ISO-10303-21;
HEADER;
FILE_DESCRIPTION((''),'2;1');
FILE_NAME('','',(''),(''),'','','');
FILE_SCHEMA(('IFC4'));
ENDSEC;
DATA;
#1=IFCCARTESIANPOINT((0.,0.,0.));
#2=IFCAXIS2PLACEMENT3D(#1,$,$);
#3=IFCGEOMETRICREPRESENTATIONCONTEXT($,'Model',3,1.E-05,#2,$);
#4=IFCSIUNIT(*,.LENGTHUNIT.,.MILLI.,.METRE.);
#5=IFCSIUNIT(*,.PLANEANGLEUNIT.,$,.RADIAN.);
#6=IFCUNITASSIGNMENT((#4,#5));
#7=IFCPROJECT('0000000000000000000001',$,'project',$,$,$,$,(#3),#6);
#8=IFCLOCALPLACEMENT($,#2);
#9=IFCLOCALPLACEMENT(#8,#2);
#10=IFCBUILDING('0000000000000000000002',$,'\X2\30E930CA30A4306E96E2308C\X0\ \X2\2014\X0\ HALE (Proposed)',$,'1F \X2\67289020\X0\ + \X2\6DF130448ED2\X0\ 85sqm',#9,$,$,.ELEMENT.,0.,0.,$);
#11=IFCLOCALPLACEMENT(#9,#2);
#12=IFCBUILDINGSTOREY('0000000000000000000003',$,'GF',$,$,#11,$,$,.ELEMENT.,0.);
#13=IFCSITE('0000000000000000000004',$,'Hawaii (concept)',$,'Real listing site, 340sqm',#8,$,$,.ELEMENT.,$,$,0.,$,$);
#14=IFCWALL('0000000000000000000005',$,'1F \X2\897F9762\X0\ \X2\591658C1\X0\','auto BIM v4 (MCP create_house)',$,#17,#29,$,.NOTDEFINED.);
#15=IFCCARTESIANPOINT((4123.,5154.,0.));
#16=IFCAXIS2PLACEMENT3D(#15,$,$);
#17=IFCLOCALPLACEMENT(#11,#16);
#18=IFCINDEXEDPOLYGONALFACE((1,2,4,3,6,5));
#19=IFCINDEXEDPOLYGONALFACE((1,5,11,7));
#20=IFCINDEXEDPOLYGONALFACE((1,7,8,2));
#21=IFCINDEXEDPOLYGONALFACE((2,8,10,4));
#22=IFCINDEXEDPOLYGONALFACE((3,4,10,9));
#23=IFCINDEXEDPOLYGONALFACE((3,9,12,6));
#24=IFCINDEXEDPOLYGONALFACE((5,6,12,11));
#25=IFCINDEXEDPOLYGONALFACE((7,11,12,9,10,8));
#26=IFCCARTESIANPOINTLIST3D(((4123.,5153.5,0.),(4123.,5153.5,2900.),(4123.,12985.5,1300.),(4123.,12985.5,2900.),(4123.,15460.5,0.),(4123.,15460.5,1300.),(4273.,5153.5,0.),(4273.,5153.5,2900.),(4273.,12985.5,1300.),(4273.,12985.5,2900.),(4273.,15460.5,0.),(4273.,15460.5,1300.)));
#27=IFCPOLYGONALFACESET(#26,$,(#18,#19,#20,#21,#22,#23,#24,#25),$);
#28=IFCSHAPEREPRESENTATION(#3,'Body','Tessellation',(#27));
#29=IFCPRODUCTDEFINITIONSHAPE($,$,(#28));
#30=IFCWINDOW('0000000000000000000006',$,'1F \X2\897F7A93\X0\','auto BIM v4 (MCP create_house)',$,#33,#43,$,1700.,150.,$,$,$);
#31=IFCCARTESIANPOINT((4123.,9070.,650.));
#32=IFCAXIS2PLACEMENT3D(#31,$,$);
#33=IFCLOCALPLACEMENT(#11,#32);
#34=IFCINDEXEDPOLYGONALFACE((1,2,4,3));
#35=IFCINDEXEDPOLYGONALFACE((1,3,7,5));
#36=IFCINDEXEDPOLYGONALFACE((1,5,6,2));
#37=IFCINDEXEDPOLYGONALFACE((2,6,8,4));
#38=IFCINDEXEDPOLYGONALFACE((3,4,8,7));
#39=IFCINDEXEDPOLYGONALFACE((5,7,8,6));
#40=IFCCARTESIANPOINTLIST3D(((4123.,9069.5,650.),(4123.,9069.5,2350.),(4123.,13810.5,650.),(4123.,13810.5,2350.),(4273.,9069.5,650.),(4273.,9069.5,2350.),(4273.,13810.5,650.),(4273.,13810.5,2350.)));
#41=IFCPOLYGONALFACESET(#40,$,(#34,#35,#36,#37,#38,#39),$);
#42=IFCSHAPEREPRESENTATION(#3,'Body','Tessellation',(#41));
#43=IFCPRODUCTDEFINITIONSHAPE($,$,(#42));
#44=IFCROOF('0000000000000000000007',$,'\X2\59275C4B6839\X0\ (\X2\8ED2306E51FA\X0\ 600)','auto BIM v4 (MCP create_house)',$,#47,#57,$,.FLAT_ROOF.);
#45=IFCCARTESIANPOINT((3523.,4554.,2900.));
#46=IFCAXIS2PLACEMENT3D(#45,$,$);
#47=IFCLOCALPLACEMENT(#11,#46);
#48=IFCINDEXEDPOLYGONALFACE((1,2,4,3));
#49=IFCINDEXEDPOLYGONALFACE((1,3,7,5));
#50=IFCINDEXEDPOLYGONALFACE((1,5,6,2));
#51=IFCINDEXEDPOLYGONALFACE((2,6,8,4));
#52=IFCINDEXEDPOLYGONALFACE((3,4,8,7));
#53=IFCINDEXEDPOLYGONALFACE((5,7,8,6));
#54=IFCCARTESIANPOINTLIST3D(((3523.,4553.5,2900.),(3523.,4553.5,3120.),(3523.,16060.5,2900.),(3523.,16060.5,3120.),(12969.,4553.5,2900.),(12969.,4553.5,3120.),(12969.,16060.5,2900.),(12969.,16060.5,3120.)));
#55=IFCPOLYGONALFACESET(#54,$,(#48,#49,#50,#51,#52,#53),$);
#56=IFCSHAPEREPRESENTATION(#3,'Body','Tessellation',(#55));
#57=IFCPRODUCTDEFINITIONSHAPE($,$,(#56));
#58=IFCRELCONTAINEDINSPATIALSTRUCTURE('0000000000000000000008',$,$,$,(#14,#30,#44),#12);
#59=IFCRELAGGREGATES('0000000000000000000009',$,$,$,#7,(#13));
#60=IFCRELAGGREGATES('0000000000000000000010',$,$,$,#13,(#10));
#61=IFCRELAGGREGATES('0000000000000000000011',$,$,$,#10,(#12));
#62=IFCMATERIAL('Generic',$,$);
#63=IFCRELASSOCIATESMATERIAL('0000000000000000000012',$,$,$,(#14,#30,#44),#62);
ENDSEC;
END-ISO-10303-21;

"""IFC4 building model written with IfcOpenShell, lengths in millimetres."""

from ifc_helpers import new_model, si_unit, frame, frame_2d, origin, place, context, project, spatial, rectangle, extrude, material, element, fill, save


model = new_model("IFC4")

# Units and contexts
model_context = context("Model", 3, precision=1e-05, world=origin())
ifc_project = project(units=[si_unit("LENGTHUNIT", "METRE", prefix="MILLI"), si_unit("PLANEANGLEUNIT", "RADIAN")], contexts=[model_context])

# Site, building, storey
site_placement = place(None, origin())
site = spatial("IfcSite", under=ifc_project, at=site_placement, Name="Hawaii (concept)", ObjectType="Real listing site, 340sqm", CompositionType="ELEMENT", RefElevation=0.0)
building_placement = place(site_placement, origin())
building = spatial("IfcBuilding", under=site, at=building_placement, Name="ラナイの離れ — HALE (Proposed)", ObjectType="1F 木造 + 深い軒 85sqm", CompositionType="ELEMENT", ElevationOfRefHeight=0.0, ElevationOfTerrain=0.0)
storey_placement = place(building_placement, origin())
storey = spatial("IfcBuildingStorey", under=building, at=storey_placement, Name="GF", CompositionType="ELEMENT", Elevation=0.0)

# Shared definitions
ifc_material = material(Name="Generic")

# Wall, opening, window
wall_1_placement = place(storey_placement, frame((4123.0, 5154.0, 0.0)))
wall_1 = element("IfcWall", 1, at=wall_1_placement, inside=storey, material=ifc_material, Name="1F 西面 外壁", Description="auto BIM v4 (MCP create_house)", PredefinedType="NOTDEFINED", context=model_context, shape_type="SweptSolid", body=[
    extrude(rectangle(XDim=150.0, YDim=10307.0, at=frame_2d((75.0, 5153.0))), frame((4123.0, 5154.0, 0.0)), (0.0, 0.0, 1.0), 2900.0),
])
opening_1_placement = place(storey_placement, frame((4123.0, 9070.0, 650.0)))
opening_1 = element("IfcOpeningElement", 2, at=opening_1_placement, cuts=wall_1, PredefinedType="NOTDEFINED", context=model_context, shape_type="SweptSolid", body=[
    extrude(rectangle(XDim=150.0, YDim=4741.0, at=frame_2d((75.0, 2370.0))), frame((4123.0, 9070.0, 650.0)), (0.0, 0.0, 1.0), 1700.0),
])
window_1_placement = place(storey_placement, frame((4123.0, 9070.0, 650.0)))
window_1 = element("IfcWindow", 3, at=window_1_placement, inside=storey, material=ifc_material, Name="1F 西窓", Description="auto BIM v4 (MCP create_house)", OverallHeight=1700.0, OverallWidth=150.0, context=model_context, shape_type="SweptSolid", body=[
    extrude(rectangle(XDim=150.0, YDim=4741.0, at=frame_2d((75.0, 2370.0))), frame((4123.0, 9070.0, 650.0)), (0.0, 0.0, 1.0), 1700.0),
])
fill(opening_1, window_1)

# Roof
roof_placement = place(storey_placement, frame((3523.0, 4554.0, 2900.0)))
element("IfcRoof", 4, at=roof_placement, inside=storey, material=ifc_material, Name="大屋根 (軒の出 600)", Description="auto BIM v4 (MCP create_house)", PredefinedType="FLAT_ROOF", context=model_context, shape_type="SweptSolid", body=[
    extrude(rectangle(XDim=9446.0, YDim=11507.0, at=frame_2d((4723.0, 5753.0))), frame((3523.0, 4554.0, 2900.0)), (0.0, 0.0, 1.0), 220.0),
])

save(model, "model.ifc")
